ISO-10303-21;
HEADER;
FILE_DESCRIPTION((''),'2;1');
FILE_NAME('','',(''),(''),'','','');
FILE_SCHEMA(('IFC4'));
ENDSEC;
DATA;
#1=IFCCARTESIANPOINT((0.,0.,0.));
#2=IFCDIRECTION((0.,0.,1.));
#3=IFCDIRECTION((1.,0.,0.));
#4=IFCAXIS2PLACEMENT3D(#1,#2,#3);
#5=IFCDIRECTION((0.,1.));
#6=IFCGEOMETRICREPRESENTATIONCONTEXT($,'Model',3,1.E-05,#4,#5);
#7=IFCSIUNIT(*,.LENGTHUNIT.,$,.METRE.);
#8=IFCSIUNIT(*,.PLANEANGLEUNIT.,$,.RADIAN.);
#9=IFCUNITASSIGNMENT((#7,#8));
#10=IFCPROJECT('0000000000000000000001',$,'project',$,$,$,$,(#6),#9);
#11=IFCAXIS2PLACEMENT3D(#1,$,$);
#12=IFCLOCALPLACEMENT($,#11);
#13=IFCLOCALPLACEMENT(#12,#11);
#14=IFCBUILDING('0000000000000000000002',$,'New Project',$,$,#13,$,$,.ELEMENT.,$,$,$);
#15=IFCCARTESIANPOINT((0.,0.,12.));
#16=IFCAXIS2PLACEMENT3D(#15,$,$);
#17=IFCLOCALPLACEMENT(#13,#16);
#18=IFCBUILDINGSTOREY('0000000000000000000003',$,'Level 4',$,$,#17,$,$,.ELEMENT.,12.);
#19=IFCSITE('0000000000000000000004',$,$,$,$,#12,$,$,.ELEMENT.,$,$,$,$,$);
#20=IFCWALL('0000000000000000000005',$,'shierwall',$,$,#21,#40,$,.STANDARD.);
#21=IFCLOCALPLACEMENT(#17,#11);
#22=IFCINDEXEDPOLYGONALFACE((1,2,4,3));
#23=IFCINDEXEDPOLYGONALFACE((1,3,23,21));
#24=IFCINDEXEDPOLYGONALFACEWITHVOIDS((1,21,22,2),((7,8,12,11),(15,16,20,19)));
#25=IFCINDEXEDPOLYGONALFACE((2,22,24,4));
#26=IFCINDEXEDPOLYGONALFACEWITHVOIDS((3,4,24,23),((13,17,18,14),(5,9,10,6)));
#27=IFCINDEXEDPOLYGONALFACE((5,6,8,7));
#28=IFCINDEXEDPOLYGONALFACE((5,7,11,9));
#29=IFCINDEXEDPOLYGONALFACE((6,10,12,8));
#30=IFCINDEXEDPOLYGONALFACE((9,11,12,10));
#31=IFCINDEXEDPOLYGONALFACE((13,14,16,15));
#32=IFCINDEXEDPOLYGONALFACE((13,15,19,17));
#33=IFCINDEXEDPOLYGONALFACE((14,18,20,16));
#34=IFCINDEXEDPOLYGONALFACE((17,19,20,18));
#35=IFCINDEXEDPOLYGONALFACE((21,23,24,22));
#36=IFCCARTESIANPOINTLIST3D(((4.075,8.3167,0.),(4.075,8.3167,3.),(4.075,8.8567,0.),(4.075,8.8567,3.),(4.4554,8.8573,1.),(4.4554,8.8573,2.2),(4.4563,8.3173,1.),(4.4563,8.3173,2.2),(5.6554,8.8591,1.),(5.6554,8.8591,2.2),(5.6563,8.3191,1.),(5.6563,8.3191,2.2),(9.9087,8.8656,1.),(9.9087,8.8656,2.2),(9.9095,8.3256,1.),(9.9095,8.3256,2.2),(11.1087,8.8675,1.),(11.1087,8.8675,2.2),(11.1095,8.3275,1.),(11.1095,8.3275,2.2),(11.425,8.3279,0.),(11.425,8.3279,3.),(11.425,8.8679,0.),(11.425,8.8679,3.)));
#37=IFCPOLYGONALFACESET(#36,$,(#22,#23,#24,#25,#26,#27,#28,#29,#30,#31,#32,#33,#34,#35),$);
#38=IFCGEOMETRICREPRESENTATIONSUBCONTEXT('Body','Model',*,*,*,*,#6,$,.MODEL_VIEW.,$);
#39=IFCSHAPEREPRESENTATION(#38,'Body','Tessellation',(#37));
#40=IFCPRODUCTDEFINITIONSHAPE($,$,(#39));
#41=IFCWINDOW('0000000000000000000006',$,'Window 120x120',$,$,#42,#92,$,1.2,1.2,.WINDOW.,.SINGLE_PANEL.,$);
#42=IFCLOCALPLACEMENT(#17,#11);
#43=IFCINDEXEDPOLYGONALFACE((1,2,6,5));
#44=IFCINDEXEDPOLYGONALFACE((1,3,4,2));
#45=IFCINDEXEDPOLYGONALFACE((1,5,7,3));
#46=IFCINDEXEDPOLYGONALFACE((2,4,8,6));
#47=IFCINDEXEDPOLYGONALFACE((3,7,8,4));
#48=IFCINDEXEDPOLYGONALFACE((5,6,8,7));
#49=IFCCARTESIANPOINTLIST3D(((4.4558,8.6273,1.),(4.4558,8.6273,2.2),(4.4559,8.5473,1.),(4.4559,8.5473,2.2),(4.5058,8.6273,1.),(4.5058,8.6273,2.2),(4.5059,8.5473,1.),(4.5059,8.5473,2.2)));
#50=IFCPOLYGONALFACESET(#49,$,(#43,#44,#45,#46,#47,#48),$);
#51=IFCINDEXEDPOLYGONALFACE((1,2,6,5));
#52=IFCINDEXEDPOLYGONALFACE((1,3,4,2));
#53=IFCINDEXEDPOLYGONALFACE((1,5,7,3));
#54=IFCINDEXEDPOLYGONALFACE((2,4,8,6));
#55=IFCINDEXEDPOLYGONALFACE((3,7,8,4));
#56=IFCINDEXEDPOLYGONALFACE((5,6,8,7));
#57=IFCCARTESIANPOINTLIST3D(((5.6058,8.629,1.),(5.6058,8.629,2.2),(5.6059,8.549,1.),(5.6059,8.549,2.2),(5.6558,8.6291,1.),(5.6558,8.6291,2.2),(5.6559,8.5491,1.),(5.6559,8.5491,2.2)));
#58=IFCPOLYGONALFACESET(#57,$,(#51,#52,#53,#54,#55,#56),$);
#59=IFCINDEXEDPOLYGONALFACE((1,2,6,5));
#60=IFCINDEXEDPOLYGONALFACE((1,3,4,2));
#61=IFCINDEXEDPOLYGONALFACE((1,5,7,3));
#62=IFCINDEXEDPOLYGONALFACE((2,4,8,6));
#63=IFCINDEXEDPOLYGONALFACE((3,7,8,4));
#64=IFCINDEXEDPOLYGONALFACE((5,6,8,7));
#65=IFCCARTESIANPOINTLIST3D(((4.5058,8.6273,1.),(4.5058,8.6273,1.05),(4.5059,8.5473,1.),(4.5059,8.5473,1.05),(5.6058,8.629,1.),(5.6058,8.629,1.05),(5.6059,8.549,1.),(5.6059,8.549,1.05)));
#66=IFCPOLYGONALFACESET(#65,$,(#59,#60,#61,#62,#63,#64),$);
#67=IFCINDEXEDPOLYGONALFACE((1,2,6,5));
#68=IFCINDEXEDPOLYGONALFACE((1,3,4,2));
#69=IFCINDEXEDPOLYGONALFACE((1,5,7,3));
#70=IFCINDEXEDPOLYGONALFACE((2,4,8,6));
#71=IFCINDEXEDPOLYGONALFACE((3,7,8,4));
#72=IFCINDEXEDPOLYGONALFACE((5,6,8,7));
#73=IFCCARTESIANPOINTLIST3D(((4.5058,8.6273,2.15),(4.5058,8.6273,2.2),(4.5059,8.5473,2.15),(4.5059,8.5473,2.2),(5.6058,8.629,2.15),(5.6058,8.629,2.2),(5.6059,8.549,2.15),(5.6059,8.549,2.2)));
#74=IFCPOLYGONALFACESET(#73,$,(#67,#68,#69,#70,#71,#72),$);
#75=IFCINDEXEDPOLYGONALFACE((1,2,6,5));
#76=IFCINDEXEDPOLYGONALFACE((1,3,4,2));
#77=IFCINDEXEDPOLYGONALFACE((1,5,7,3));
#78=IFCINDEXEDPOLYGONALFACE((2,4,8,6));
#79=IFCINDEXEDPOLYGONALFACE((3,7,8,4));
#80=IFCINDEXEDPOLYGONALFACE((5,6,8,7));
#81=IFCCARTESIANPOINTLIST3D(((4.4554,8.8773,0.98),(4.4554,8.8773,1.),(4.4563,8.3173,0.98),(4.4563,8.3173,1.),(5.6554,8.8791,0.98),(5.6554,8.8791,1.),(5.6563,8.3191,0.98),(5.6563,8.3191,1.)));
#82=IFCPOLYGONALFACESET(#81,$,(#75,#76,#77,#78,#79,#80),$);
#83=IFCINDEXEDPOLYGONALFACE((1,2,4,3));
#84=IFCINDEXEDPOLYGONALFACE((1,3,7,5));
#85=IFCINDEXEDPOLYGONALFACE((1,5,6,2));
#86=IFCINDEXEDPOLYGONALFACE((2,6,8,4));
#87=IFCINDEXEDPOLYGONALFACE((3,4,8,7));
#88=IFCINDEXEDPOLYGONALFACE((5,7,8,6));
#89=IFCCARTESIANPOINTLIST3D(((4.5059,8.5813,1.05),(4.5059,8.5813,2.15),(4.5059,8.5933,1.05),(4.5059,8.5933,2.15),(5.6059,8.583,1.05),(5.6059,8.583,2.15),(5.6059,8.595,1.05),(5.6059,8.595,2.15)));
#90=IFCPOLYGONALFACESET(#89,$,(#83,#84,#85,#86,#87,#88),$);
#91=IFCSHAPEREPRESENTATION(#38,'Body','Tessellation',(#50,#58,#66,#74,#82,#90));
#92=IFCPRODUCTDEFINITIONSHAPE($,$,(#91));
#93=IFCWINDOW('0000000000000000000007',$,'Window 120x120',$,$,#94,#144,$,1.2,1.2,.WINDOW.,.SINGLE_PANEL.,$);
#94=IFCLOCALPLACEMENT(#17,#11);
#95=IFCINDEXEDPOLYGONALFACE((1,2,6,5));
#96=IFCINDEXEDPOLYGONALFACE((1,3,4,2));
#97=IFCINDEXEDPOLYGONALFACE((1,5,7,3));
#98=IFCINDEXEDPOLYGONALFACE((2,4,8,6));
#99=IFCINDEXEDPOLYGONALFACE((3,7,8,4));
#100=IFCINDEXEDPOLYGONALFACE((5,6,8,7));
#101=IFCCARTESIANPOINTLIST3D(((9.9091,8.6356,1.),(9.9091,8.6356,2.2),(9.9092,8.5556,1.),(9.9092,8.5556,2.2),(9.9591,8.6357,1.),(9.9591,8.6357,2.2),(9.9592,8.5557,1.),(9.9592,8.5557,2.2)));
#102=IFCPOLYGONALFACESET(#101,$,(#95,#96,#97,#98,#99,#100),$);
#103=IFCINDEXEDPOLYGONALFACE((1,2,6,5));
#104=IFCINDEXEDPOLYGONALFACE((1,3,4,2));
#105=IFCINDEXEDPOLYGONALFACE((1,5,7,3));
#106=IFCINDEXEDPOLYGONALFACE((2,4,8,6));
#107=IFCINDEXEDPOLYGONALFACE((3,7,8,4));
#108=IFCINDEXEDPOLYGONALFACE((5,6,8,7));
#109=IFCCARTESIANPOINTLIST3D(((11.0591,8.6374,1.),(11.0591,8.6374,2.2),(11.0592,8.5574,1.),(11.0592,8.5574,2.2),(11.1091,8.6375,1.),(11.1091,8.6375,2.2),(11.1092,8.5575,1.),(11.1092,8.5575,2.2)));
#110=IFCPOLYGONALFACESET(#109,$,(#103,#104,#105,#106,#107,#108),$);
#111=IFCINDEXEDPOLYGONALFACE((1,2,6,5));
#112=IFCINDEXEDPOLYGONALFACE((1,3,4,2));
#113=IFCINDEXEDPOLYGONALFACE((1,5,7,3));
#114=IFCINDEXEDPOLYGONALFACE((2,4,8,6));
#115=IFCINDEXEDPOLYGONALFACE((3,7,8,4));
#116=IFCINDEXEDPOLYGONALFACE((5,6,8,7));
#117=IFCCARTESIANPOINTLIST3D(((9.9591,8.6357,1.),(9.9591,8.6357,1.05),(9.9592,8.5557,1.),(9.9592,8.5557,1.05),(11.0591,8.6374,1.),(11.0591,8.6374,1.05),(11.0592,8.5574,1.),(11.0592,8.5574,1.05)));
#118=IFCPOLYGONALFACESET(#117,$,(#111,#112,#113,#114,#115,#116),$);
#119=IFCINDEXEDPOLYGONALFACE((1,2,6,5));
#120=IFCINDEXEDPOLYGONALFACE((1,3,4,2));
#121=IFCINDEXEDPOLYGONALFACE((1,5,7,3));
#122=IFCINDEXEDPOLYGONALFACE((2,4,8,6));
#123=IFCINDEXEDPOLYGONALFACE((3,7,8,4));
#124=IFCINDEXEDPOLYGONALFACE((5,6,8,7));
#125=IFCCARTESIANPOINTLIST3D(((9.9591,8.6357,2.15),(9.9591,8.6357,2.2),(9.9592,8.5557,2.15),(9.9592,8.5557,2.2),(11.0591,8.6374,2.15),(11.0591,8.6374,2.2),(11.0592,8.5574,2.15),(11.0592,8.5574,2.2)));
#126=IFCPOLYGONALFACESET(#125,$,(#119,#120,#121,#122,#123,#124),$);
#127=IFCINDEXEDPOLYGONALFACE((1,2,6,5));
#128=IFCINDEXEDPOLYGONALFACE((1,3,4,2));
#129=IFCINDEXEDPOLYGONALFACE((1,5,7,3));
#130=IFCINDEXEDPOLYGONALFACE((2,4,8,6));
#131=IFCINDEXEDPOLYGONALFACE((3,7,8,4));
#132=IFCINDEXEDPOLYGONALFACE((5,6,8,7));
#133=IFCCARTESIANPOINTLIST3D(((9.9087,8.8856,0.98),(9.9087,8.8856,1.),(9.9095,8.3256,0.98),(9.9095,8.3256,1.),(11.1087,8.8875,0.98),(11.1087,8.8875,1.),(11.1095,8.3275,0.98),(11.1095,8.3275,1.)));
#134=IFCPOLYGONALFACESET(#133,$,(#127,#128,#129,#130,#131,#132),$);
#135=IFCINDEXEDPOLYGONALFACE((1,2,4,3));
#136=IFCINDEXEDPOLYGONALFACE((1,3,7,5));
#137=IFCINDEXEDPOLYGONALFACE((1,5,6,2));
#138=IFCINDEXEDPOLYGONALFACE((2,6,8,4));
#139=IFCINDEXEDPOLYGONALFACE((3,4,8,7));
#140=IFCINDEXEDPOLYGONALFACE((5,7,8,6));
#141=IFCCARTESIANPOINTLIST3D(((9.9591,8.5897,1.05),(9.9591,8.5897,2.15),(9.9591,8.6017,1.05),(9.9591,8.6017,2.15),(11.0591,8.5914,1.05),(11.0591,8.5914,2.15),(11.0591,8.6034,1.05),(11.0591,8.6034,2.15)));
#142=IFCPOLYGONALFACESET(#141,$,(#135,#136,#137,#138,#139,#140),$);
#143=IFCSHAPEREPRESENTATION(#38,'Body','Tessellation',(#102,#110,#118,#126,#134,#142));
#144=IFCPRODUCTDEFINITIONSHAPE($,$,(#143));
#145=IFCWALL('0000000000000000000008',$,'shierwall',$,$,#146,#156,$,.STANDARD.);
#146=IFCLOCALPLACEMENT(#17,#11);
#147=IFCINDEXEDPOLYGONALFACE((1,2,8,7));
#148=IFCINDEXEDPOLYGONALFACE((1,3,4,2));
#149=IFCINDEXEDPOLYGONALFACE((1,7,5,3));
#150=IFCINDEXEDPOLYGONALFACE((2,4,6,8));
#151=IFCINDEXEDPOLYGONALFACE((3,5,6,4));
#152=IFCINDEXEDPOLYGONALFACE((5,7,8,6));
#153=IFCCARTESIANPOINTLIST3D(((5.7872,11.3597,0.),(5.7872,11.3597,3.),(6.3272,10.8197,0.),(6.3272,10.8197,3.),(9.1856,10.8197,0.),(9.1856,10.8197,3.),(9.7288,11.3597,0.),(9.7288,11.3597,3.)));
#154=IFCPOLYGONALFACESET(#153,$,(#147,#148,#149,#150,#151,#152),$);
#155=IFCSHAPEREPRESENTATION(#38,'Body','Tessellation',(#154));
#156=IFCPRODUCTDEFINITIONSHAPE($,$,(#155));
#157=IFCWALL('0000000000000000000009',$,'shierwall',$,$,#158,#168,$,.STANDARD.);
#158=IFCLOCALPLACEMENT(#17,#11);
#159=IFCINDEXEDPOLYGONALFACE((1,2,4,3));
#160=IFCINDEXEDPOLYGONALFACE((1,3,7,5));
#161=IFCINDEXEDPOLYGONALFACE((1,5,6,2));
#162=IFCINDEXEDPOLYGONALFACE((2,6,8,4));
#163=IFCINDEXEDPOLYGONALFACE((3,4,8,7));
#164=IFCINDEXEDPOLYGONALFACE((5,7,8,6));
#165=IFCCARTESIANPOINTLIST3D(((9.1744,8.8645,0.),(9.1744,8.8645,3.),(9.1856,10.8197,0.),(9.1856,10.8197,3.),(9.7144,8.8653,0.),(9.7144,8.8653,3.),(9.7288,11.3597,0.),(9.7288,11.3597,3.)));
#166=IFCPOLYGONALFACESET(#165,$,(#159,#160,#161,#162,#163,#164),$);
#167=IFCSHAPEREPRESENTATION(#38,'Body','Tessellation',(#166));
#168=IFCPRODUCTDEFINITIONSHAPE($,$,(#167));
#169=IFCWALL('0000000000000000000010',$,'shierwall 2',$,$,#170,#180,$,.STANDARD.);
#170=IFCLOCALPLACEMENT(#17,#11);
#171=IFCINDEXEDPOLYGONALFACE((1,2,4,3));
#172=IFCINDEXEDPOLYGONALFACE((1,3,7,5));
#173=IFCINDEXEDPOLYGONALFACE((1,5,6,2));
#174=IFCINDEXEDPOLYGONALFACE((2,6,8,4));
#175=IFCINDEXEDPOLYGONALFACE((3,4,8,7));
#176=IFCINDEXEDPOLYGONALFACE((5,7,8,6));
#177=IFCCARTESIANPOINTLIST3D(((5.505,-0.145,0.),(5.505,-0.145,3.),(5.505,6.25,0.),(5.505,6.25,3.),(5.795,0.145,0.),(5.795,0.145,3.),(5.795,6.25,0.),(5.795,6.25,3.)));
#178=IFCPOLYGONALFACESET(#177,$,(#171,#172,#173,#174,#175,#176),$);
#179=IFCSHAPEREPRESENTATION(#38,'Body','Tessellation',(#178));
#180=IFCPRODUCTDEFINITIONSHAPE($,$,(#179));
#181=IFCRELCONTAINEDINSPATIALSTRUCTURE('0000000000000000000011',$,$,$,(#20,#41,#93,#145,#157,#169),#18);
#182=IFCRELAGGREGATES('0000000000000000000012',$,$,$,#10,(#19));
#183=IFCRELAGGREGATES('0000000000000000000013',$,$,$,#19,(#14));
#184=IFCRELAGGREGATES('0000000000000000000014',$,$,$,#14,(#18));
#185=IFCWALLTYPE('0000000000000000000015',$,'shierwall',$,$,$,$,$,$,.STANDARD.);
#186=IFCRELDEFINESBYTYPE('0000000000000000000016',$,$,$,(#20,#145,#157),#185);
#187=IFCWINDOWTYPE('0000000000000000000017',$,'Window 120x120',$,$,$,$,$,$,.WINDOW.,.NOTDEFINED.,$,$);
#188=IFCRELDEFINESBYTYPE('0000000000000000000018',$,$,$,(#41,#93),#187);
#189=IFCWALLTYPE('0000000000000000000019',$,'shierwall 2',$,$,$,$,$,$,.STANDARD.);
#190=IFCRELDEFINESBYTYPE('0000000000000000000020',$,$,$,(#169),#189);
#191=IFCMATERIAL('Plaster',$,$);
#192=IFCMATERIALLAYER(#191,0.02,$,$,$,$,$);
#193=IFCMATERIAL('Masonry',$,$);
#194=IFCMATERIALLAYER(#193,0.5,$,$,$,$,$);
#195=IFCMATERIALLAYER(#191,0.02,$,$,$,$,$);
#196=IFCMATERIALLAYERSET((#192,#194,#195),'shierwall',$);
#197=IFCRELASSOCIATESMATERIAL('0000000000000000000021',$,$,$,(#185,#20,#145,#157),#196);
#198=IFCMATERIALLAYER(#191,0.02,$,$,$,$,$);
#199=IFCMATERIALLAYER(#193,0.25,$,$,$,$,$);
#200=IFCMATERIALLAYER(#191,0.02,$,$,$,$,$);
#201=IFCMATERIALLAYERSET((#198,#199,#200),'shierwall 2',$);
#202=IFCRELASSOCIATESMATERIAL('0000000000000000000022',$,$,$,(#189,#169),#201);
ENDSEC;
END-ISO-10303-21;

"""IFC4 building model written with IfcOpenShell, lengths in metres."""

from ifc_helpers import new_model, si_unit, direction, frame, frame_2d, origin, origin_with_axes, place, context, subcontext, project, spatial, polyline, rectangle, outline, extrude, material, layer, layer_set, layer_usage, type_object, element, fill, save


model = new_model("IFC4")

# Units and contexts
model_context = context("Model", 3, precision=1e-05, world=origin_with_axes(), true_north=direction((0.0, 1.0)))
body_context = subcontext(model_context, "Body", "Model", "MODEL_VIEW")
ifc_project = project(units=[si_unit("LENGTHUNIT", "METRE"), si_unit("PLANEANGLEUNIT", "RADIAN")], contexts=[model_context])

# Site, building, storey
site_placement = place(None, origin())
site = spatial("IfcSite", under=ifc_project, at=site_placement, CompositionType="ELEMENT")
building_placement = place(site_placement, origin())
building = spatial("IfcBuilding", under=site, at=building_placement, Name="New Project", CompositionType="ELEMENT")
storey_placement = place(building_placement, frame((0.0, 0.0, 12.0)))
storey = spatial("IfcBuildingStorey", under=building, at=storey_placement, Name="Level 4", CompositionType="ELEMENT", Elevation=12.0)

# Shared definitions
ifc_material_1 = material(Name="Plaster")
ifc_material_2 = material(Name="Masonry")
window_type = type_object("IfcWindowType", Name="Window 120x120", PartitioningType="NOTDEFINED", PredefinedType="WINDOW")

# Wall, openings, windows
ifc_layer_1 = layer(ifc_material_1, 0.02)
ifc_layer_2 = layer(ifc_material_2, 0.5)
ifc_layer_3 = layer(ifc_material_1, 0.02)
ifc_layer_set_1 = layer_set([ifc_layer_1, ifc_layer_2, ifc_layer_3], Name="shierwall")
ifc_layer_usage_1 = layer_usage(ifc_layer_set_1, "AXIS2", "NEGATIVE", 0.27)
wall_type_1 = type_object("IfcWallType", Name="shierwall", PredefinedType="STANDARD", material=ifc_layer_set_1)
wall_1_placement = place(storey_placement, frame((4.075, 8.5867, 0.0), z_axis=(0.0, 0.0, 1.0), x_axis=(0.999999, 0.001534, 0.0)))
wall_1 = element("IfcWall", 1, at=wall_1_placement, inside=storey, type_object=wall_type_1, material=ifc_layer_usage_1, Name="shierwall", PredefinedType="STANDARD", context=body_context, shape_type="SweptSolid", body=[
    extrude(outline(polyline([(-0.0004, -0.27), (7.3496, -0.27), (7.3504, 0.27), (0.0004, 0.27), (-0.0004, -0.27)])), origin(), (0.0, 0.0, 1.0), 3.0),
])
opening_1_placement = place(wall_1_placement, frame((0.3809, 0.0, 1.0)))
opening_1 = element("IfcOpeningElement", 2, at=opening_1_placement, cuts=wall_1, PredefinedType="OPENING", context=body_context, shape_type="SweptSolid", body=[
    extrude(rectangle(XDim=1.2, YDim=0.64, at=frame_2d((0.6, 0.0))), origin(), (0.0, 0.0, 1.0), 1.2),
])
opening_2_placement = place(wall_1_placement, frame((5.8341, 0.0, 1.0)))
opening_2 = element("IfcOpeningElement", 3, at=opening_2_placement, cuts=wall_1, PredefinedType="OPENING", context=body_context, shape_type="SweptSolid", body=[
    extrude(rectangle(XDim=1.2, YDim=0.64, at=frame_2d((0.6, 0.0))), origin(), (0.0, 0.0, 1.0), 1.2),
])
window_1_placement = place(opening_1_placement, origin())
window_1 = element("IfcWindow", 4, at=window_1_placement, inside=storey, type_object=window_type, Name="Window 120x120", OverallHeight=1.2, OverallWidth=1.2, PartitioningType="SINGLE_PANEL", PredefinedType="WINDOW", context=body_context, shape_type="SweptSolid", body=[
    extrude(outline(polyline([(0.0, -0.04), (0.05, -0.04), (0.05, 0.04), (0.0, 0.04), (0.0, -0.04)])), origin(), (0.0, 0.0, 1.0), 1.2),
    extrude(outline(polyline([(1.15, -0.04), (1.2, -0.04), (1.2, 0.04), (1.15, 0.04), (1.15, -0.04)])), origin(), (0.0, 0.0, 1.0), 1.2),
    extrude(outline(polyline([(0.05, -0.04), (1.15, -0.04), (1.15, 0.04), (0.05, 0.04), (0.05, -0.04)])), origin(), (0.0, 0.0, 1.0), 0.05),
    extrude(outline(polyline([(0.05, -0.04), (1.15, -0.04), (1.15, 0.04), (0.05, 0.04), (0.05, -0.04)])), frame((0.0, 0.0, 1.15)), (0.0, 0.0, 1.0), 0.05),
    extrude(outline(polyline([(0.0, -0.27), (1.2, -0.27), (1.2, 0.29), (0.0, 0.29), (0.0, -0.27)])), frame((0.0, 0.0, -0.02)), (0.0, 0.0, 1.0), 0.02),
    extrude(outline(polyline([(0.05, -0.006), (1.15, -0.006), (1.15, 0.006), (0.05, 0.006), (0.05, -0.006)])), frame((0.0, 0.0, 0.05)), (0.0, 0.0, 1.0), 1.1),
])
fill(opening_1, window_1)
window_2_placement = place(opening_2_placement, origin())
window_2 = element("IfcWindow", 5, at=window_2_placement, inside=storey, type_object=window_type, Name="Window 120x120", OverallHeight=1.2, OverallWidth=1.2, PartitioningType="SINGLE_PANEL", PredefinedType="WINDOW", context=body_context, shape_type="SweptSolid", body=[
    extrude(outline(polyline([(0.0, -0.04), (0.05, -0.04), (0.05, 0.04), (0.0, 0.04), (0.0, -0.04)])), origin(), (0.0, 0.0, 1.0), 1.2),
    extrude(outline(polyline([(1.15, -0.04), (1.2, -0.04), (1.2, 0.04), (1.15, 0.04), (1.15, -0.04)])), origin(), (0.0, 0.0, 1.0), 1.2),
    extrude(outline(polyline([(0.05, -0.04), (1.15, -0.04), (1.15, 0.04), (0.05, 0.04), (0.05, -0.04)])), origin(), (0.0, 0.0, 1.0), 0.05),
    extrude(outline(polyline([(0.05, -0.04), (1.15, -0.04), (1.15, 0.04), (0.05, 0.04), (0.05, -0.04)])), frame((0.0, 0.0, 1.15)), (0.0, 0.0, 1.0), 0.05),
    extrude(outline(polyline([(0.0, -0.27), (1.2, -0.27), (1.2, 0.29), (0.0, 0.29), (0.0, -0.27)])), frame((0.0, 0.0, -0.02)), (0.0, 0.0, 1.0), 0.02),
    extrude(outline(polyline([(0.05, -0.006), (1.15, -0.006), (1.15, 0.006), (0.05, 0.006), (0.05, -0.006)])), frame((0.0, 0.0, 0.05)), (0.0, 0.0, 1.0), 1.1),
])
fill(opening_2, window_2)

# Walls
wall_2_placement = place(storey_placement, frame((6.0572, 11.0897, 0.0)))
element("IfcWall", 6, at=wall_2_placement, inside=storey, type_object=wall_type_1, material=ifc_layer_usage_1, Name="shierwall", PredefinedType="STANDARD", context=body_context, shape_type="SweptSolid", body=[
    extrude(outline(polyline([(0.27, -0.27), (3.1284, -0.27), (3.6716, 0.27), (-0.27, 0.27), (0.27, -0.27)])), origin(), (0.0, 0.0, 1.0), 3.0),
])
wall_3_placement = place(storey_placement, frame((9.4572, 11.0897, 0.0), z_axis=(0.0, 0.0, 1.0), x_axis=(-0.005766, -0.999983, 0.0)))
element("IfcWall", 7, at=wall_3_placement, inside=storey, type_object=wall_type_1, material=ifc_layer_usage_1, Name="shierwall", PredefinedType="STANDARD", context=body_context, shape_type="SweptSolid", body=[
    extrude(outline(polyline([(0.2716, -0.27), (2.2268, -0.27), (2.2229, 0.27), (-0.2716, 0.27), (0.2716, -0.27)])), origin(), (0.0, 0.0, 1.0), 3.0),
])
ifc_layer_4 = layer(ifc_material_1, 0.02)
ifc_layer_5 = layer(ifc_material_2, 0.25)
ifc_layer_6 = layer(ifc_material_1, 0.02)
ifc_layer_set_2 = layer_set([ifc_layer_4, ifc_layer_5, ifc_layer_6], Name="shierwall 2")
ifc_layer_usage_2 = layer_usage(ifc_layer_set_2, "AXIS2", "NEGATIVE", 0.145)
wall_type_2 = type_object("IfcWallType", Name="shierwall 2", PredefinedType="STANDARD", material=ifc_layer_set_2)
wall_4_placement = place(storey_placement, frame((5.65, 6.25, 0.0), z_axis=(0.0, 0.0, 1.0), x_axis=(0.0, -1.0, 0.0)))
element("IfcWall", 8, at=wall_4_placement, inside=storey, type_object=wall_type_2, material=ifc_layer_usage_2, Name="shierwall 2", PredefinedType="STANDARD", context=body_context, shape_type="SweptSolid", body=[
    extrude(outline(polyline([(0.0, -0.145), (6.395, -0.145), (6.105, 0.145), (0.0, 0.145), (0.0, -0.145)])), origin(), (0.0, 0.0, 1.0), 3.0),
])

save(model, "model.ifc")
